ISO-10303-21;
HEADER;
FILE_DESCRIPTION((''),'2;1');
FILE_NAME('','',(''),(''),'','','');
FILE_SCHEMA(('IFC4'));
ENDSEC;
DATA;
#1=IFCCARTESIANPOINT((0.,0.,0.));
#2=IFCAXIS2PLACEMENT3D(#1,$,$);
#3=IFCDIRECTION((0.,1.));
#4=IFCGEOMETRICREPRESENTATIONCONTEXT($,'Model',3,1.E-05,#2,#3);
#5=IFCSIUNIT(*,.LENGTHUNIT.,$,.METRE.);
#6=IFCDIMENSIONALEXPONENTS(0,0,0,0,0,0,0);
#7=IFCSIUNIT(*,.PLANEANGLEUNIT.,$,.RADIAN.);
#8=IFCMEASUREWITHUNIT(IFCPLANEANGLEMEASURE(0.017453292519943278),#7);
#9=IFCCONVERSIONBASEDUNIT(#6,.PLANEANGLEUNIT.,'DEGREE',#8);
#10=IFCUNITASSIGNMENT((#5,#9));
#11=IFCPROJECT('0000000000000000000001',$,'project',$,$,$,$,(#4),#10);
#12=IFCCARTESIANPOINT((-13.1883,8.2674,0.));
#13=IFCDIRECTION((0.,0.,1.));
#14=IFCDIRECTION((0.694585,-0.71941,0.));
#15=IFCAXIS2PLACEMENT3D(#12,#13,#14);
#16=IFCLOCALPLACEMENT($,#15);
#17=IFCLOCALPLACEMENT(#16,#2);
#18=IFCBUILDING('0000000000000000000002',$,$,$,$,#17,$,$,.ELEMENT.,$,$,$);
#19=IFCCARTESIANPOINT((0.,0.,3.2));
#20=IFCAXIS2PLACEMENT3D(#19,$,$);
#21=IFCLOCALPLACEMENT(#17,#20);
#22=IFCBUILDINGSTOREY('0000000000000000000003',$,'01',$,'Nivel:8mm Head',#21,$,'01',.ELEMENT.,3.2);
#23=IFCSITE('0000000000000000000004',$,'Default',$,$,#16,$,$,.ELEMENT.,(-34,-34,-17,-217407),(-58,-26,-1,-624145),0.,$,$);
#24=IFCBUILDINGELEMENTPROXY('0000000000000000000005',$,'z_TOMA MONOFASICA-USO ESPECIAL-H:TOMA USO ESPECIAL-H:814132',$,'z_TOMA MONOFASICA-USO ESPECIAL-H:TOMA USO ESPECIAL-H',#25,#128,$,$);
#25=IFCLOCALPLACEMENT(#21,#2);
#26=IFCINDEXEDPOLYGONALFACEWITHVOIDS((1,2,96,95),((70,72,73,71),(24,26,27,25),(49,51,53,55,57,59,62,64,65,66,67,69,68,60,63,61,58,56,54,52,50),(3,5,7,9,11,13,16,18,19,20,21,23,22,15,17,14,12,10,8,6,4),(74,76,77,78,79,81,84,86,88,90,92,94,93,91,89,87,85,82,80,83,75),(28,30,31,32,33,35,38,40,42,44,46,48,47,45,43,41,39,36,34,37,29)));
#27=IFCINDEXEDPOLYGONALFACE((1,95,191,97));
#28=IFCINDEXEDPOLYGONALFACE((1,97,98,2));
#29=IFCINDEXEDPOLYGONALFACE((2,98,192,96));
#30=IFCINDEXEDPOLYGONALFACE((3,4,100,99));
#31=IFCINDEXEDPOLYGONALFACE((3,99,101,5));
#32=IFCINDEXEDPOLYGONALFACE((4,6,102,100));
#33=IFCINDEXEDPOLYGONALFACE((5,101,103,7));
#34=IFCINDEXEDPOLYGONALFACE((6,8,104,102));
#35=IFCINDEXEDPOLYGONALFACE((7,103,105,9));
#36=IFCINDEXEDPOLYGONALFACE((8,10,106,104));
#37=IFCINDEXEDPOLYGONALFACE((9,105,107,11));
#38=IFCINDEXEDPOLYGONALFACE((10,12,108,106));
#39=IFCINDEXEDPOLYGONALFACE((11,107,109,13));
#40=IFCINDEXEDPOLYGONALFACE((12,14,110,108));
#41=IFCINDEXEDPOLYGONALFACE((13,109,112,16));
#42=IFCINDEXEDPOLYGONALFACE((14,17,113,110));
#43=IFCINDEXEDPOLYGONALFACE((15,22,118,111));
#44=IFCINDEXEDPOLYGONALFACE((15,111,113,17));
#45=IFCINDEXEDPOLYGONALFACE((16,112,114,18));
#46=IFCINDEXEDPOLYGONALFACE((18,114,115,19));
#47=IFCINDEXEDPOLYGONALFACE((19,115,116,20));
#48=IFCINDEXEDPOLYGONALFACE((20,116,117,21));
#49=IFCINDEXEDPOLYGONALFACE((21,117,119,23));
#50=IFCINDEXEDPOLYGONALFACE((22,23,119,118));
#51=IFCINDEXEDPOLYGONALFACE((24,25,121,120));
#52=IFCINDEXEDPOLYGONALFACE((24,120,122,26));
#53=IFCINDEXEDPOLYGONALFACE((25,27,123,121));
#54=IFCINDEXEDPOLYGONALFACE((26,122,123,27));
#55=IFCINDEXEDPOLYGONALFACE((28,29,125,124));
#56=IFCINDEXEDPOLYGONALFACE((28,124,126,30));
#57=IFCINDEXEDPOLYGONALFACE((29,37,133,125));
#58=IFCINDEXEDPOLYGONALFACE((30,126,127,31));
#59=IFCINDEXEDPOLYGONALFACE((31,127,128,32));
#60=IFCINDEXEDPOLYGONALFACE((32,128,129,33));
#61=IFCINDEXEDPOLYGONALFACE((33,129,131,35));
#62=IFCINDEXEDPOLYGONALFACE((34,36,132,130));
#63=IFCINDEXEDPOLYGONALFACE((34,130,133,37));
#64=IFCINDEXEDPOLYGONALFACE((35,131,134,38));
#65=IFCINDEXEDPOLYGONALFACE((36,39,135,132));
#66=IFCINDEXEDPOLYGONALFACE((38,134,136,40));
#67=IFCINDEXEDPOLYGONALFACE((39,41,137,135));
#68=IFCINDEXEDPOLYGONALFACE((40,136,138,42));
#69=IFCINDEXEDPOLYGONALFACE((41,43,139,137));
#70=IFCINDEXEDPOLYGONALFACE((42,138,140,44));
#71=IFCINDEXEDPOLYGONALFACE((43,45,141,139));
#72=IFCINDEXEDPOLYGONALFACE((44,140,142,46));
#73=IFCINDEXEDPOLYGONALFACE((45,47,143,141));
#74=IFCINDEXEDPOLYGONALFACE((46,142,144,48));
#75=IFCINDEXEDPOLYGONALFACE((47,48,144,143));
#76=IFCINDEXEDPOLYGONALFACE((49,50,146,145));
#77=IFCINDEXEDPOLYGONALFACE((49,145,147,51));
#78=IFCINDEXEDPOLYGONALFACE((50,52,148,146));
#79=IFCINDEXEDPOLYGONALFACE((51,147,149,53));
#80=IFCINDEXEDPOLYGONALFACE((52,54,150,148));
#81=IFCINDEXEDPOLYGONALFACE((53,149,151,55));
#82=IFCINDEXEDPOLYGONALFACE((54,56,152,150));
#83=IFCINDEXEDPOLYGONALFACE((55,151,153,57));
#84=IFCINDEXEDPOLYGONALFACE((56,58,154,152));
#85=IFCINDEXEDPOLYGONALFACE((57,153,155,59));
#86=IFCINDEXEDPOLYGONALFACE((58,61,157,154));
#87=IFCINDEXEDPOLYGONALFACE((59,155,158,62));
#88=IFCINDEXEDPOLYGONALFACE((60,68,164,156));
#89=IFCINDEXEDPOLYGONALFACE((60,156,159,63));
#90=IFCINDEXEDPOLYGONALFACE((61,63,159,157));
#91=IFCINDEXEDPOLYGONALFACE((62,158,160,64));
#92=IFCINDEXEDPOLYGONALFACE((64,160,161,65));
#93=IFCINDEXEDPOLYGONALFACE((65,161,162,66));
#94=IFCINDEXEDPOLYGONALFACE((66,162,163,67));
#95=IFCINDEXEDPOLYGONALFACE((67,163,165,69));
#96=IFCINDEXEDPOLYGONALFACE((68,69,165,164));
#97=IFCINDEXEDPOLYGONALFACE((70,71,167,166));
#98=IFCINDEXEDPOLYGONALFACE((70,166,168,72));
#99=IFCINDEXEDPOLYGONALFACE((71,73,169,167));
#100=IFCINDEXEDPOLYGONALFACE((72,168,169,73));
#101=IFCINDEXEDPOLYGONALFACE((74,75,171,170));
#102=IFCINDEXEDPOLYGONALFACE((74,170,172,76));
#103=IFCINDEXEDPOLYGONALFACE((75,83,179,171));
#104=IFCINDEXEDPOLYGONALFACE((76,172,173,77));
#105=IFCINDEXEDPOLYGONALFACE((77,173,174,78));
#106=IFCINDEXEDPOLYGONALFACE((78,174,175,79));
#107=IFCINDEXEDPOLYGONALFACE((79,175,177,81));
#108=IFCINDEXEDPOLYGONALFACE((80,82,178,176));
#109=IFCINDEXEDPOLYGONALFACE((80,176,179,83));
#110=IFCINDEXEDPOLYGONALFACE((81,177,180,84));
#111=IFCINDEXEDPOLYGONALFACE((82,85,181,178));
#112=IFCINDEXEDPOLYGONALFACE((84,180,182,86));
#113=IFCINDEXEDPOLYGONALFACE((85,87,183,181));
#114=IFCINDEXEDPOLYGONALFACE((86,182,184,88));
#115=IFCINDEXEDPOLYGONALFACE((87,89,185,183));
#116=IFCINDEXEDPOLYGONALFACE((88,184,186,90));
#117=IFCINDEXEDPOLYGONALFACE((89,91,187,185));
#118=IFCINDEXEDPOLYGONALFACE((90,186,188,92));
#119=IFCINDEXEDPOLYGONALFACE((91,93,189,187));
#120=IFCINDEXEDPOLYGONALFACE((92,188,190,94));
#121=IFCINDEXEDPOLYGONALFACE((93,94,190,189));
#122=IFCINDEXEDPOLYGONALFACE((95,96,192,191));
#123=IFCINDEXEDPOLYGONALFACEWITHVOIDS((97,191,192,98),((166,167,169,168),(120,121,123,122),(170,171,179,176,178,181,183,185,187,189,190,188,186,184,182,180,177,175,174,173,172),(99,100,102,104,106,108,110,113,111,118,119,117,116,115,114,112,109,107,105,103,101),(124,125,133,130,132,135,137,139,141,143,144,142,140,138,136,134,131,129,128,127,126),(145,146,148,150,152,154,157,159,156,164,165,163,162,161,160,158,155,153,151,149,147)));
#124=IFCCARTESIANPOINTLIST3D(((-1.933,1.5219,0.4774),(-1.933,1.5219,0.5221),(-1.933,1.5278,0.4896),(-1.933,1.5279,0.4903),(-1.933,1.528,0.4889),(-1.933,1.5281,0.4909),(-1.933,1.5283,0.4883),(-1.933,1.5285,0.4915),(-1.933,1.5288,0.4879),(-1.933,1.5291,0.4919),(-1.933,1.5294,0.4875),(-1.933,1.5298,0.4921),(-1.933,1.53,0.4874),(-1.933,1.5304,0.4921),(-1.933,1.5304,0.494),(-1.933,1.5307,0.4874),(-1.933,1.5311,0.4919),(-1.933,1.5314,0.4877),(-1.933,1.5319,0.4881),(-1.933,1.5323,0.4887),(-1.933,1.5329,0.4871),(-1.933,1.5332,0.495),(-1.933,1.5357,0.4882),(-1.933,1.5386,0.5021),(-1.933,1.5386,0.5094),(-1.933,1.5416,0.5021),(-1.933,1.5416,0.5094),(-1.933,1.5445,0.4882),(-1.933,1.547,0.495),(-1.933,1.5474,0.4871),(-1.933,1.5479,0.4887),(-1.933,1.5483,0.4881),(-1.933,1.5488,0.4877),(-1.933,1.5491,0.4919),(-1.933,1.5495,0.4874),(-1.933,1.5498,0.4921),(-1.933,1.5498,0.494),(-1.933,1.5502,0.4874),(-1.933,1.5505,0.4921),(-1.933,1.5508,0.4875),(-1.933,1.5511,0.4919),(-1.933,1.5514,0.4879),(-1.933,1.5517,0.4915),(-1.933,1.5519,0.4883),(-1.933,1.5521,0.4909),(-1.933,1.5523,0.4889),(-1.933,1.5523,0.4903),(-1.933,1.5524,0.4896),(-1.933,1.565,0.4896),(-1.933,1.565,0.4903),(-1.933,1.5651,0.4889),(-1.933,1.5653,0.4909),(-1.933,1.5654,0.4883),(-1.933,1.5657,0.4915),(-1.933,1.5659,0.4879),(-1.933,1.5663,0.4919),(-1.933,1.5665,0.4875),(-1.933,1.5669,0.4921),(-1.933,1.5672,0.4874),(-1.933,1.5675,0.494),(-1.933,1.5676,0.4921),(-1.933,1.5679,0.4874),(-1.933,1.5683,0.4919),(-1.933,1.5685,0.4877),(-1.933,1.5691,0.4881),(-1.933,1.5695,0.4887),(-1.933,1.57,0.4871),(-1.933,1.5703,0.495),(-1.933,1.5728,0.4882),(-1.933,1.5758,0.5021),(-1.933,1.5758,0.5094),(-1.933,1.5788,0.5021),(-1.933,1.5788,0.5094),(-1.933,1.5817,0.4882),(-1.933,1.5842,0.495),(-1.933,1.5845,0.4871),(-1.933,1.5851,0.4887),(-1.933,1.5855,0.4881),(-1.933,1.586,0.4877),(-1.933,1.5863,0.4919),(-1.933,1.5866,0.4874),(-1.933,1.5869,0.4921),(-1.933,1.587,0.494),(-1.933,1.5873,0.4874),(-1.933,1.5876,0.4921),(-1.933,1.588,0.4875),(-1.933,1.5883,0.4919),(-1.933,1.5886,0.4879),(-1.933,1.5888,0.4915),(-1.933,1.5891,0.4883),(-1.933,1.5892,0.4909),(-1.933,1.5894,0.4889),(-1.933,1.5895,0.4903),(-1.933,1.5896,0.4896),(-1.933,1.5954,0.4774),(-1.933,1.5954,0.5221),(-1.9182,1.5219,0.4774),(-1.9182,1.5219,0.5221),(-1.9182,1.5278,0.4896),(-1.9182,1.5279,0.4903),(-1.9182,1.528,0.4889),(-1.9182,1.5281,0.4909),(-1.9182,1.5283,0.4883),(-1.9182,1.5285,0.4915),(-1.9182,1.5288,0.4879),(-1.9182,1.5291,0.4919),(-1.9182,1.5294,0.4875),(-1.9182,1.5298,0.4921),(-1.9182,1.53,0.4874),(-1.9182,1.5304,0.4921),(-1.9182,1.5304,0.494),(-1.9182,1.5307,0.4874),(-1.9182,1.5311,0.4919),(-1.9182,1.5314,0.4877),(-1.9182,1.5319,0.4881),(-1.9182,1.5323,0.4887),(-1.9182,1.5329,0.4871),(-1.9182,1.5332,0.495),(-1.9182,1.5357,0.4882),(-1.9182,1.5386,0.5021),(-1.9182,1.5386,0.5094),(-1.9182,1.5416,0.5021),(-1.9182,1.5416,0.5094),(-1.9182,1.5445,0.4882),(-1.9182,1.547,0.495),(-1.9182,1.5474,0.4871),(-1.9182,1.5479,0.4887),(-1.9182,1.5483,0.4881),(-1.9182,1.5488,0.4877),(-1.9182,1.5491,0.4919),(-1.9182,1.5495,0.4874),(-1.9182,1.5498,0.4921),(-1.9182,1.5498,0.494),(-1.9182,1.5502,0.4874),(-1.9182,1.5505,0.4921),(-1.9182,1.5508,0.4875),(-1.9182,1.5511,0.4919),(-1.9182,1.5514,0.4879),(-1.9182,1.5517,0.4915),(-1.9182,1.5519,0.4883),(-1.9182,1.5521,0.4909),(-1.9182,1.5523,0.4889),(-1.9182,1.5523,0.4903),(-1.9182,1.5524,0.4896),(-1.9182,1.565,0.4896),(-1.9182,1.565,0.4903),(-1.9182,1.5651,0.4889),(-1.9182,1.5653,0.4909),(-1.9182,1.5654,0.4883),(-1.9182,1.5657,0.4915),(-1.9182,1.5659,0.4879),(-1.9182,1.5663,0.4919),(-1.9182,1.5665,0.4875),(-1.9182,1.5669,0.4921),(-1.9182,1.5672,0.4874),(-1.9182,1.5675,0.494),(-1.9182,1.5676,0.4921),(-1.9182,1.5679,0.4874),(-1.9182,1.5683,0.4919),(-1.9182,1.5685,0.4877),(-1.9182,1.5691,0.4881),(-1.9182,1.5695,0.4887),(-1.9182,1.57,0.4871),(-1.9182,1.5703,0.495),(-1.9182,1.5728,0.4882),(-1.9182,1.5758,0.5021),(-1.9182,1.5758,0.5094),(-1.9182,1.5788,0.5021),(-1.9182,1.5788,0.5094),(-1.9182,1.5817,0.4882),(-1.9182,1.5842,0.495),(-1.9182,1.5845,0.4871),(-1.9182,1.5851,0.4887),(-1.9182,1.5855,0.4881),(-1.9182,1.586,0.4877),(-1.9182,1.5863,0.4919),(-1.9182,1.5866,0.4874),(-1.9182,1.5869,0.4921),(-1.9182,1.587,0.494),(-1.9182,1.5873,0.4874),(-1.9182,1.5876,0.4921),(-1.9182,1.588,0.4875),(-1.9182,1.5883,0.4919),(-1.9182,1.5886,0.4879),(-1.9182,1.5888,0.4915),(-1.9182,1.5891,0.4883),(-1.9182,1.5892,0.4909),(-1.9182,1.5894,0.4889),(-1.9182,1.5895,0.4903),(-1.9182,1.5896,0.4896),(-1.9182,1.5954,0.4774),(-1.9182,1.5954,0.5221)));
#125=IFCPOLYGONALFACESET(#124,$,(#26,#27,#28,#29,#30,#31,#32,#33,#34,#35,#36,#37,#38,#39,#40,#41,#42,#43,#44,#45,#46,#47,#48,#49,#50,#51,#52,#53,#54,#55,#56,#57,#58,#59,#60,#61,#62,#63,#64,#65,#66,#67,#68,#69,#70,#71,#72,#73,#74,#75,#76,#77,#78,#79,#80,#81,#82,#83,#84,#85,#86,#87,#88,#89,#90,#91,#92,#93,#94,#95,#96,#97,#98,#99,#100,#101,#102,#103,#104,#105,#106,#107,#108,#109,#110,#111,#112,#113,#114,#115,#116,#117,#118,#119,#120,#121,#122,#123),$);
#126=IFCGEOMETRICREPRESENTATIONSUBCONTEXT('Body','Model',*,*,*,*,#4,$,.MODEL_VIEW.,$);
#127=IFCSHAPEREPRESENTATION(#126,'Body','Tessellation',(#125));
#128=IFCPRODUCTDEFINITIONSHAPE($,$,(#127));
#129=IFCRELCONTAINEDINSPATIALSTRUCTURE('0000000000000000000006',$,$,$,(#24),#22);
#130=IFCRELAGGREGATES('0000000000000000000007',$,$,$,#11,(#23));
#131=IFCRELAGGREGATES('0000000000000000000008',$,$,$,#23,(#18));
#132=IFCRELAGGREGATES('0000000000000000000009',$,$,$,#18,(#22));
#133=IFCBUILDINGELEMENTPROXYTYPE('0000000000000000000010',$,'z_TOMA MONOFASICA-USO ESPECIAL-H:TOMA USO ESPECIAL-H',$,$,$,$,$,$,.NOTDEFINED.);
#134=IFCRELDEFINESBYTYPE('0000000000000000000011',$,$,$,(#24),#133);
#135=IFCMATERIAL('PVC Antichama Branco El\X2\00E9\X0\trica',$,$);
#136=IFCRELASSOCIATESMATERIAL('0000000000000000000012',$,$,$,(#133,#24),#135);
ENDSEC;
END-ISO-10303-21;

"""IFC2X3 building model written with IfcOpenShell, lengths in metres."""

from ifc_helpers import new_model, entity, si_unit, converted_unit, direction, frame, frame_2d, origin, place, context, subcontext, project, spatial, polyline, circle_curve, parameter, trimmed, segment, composite_curve, outline, extrude, source, transform, mapped, material, type_object, type_shapes, element, save


model = new_model("IFC2X3")

# Units and contexts
model_context = context("Model", 3, precision=1e-05, world=origin(), true_north=direction((0.0, 1.0)))
body_context = subcontext(model_context, "Body", "Model", "MODEL_VIEW")
ifc_project = project(units=[si_unit("LENGTHUNIT", "METRE"), converted_unit("PLANEANGLEUNIT", "DEGREE", entity("IfcPlaneAngleMeasure", 0.017453292519943278), si_unit("PLANEANGLEUNIT", "RADIAN"), dimensions=[0, 0, 0, 0, 0, 0, 0])], contexts=[model_context])

# Site, building, storey
site_placement = place(None, frame((-13.1883, 8.2674, 0.0), z_axis=(0.0, 0.0, 1.0), x_axis=(0.694585, -0.71941, 0.0)))
site = spatial("IfcSite", under=ifc_project, at=site_placement, Name="Default", CompositionType="ELEMENT", RefLatitude=(-34, -34, -17, -217407), RefLongitude=(-58, -26, -1, -624145), RefElevation=0.0)
building_placement = place(site_placement, origin())
building = spatial("IfcBuilding", under=site, at=building_placement, CompositionType="ELEMENT")
storey_placement = place(building_placement, frame((0.0, 0.0, 3.2)))
storey = spatial("IfcBuildingStorey", under=building, at=storey_placement, Name="01", ObjectType="Nivel:8mm Head", LongName="01", CompositionType="ELEMENT", Elevation=3.2)

# Building element proxy
ifc_material_1 = material(Name="PVC Antichama Branco Elétrica")
building_element_proxy_type_1 = type_object("IfcBuildingElementProxyType", Name="z_TOMA MONOFASICA-USO ESPECIAL-H:TOMA USO ESPECIAL-H", PredefinedType="NOTDEFINED", material=ifc_material_1)
shared_shape_1 = source(origin(), body_context, "Body", "SweptSolid", [
    extrude(outline(polyline([(-0.0368, -0.0223), (0.0368, -0.0223), (0.0368, 0.0223), (-0.0368, 0.0223), (-0.0368, -0.0223)]), holes=[composite_curve([segment(polyline([(0.0141, 0.0115), (0.0116, 0.0047)]), True, "CONTINUOUS"), segment(polyline([(0.0116, 0.0047), (0.0088, 0.0057)]), True, "CONTINUOUS"), segment(polyline([(0.0088, 0.0057), (0.0096, 0.0078)]), True, "CONTINUOUS"), segment(trimmed(circle_curve(frame_2d((0.0087, 0.0099), x_axis=(1.0, 0.0)), 0.0024), [parameter(27.118901)], [parameter(292.881099)], True, "PARAMETER"), False, "CONTINUOUS"), segment(polyline([(0.0108, 0.011), (0.0113, 0.0126)]), True, "CONTINUOUS"), segment(polyline([(0.0113, 0.0126), (0.0141, 0.0115)]), True, "CONTINUOUS")], self_intersect=False), composite_curve([segment(polyline([(0.0255, 0.0047), (0.023, 0.0115)]), True, "CONTINUOUS"), segment(polyline([(0.023, 0.0115), (0.0258, 0.0126)]), True, "CONTINUOUS"), segment(polyline([(0.0258, 0.0126), (0.0264, 0.011)]), True, "CONTINUOUS"), segment(trimmed(circle_curve(frame_2d((0.0285, 0.0099), x_axis=(1.0, 0.0)), 0.0024), [parameter(247.118901)], [parameter(152.881099)], True, "PARAMETER"), False, "CONTINUOUS"), segment(polyline([(0.0276, 0.0078), (0.0283, 0.0057)]), True, "CONTINUOUS"), segment(polyline([(0.0283, 0.0057), (0.0255, 0.0047)]), True, "CONTINUOUS")], self_intersect=False), polyline([(0.0201, -0.0024), (0.0201, -0.0097), (0.0171, -0.0097), (0.0171, -0.0024), (0.0201, -0.0024)]), composite_curve([segment(polyline([(-0.0141, 0.0115), (-0.0113, 0.0126)]), True, "CONTINUOUS"), segment(polyline([(-0.0113, 0.0126), (-0.0108, 0.011)]), True, "CONTINUOUS"), segment(trimmed(circle_curve(frame_2d((-0.0087, 0.0099), x_axis=(1.0, 0.0)), 0.0024), [parameter(247.118901)], [parameter(152.881099)], True, "PARAMETER"), False, "CONTINUOUS"), segment(polyline([(-0.0096, 0.0078), (-0.0088, 0.0057)]), True, "CONTINUOUS"), segment(polyline([(-0.0088, 0.0057), (-0.0116, 0.0047)]), True, "CONTINUOUS"), segment(polyline([(-0.0116, 0.0047), (-0.0141, 0.0115)]), True, "CONTINUOUS")], self_intersect=False), composite_curve([segment(polyline([(-0.0255, 0.0047), (-0.0283, 0.0057)]), True, "CONTINUOUS"), segment(polyline([(-0.0283, 0.0057), (-0.0276, 0.0078)]), True, "CONTINUOUS"), segment(trimmed(circle_curve(frame_2d((-0.0285, 0.0099), x_axis=(1.0, 0.0)), 0.0024), [parameter(27.118901)], [parameter(292.881099)], True, "PARAMETER"), False, "CONTINUOUS"), segment(polyline([(-0.0264, 0.011), (-0.0258, 0.0126)]), True, "CONTINUOUS"), segment(polyline([(-0.0258, 0.0126), (-0.023, 0.0115)]), True, "CONTINUOUS"), segment(polyline([(-0.023, 0.0115), (-0.0255, 0.0047)]), True, "CONTINUOUS")], self_intersect=False), polyline([(-0.0201, -0.0024), (-0.0171, -0.0024), (-0.0171, -0.0097), (-0.0201, -0.0097), (-0.0201, -0.0024)])]), frame((0.0, -0.005, 0.0223), z_axis=(0.0, 1.0, 0.0), x_axis=(1.0, 0.0, 0.0)), (0.0, 0.0, 1.0), 0.0148),
])
type_shapes(building_element_proxy_type_1, [shared_shape_1])
for number, where, z_axis, x_axis, name in (
    (1, (-1.928, 1.5587, 0.4774), (0.0, 0.0, 1.0), (0.0, -1.0, 0.0), "z_TOMA MONOFASICA-USO ESPECIAL-H:TOMA USO ESPECIAL-H:814132"),
):
    element("IfcBuildingElementProxy", number, at=place(storey_placement, frame(where, z_axis=z_axis, x_axis=x_axis)), inside=storey, type_object=building_element_proxy_type_1, material=ifc_material_1, Name=name, ObjectType="z_TOMA MONOFASICA-USO ESPECIAL-H:TOMA USO ESPECIAL-H", context=body_context, shape_type="MappedRepresentation", body=[
        mapped(shared_shape_1, transform((0.0, 0.0, 0.0), scale=1.0)),
    ])

save(model, "model.ifc")
